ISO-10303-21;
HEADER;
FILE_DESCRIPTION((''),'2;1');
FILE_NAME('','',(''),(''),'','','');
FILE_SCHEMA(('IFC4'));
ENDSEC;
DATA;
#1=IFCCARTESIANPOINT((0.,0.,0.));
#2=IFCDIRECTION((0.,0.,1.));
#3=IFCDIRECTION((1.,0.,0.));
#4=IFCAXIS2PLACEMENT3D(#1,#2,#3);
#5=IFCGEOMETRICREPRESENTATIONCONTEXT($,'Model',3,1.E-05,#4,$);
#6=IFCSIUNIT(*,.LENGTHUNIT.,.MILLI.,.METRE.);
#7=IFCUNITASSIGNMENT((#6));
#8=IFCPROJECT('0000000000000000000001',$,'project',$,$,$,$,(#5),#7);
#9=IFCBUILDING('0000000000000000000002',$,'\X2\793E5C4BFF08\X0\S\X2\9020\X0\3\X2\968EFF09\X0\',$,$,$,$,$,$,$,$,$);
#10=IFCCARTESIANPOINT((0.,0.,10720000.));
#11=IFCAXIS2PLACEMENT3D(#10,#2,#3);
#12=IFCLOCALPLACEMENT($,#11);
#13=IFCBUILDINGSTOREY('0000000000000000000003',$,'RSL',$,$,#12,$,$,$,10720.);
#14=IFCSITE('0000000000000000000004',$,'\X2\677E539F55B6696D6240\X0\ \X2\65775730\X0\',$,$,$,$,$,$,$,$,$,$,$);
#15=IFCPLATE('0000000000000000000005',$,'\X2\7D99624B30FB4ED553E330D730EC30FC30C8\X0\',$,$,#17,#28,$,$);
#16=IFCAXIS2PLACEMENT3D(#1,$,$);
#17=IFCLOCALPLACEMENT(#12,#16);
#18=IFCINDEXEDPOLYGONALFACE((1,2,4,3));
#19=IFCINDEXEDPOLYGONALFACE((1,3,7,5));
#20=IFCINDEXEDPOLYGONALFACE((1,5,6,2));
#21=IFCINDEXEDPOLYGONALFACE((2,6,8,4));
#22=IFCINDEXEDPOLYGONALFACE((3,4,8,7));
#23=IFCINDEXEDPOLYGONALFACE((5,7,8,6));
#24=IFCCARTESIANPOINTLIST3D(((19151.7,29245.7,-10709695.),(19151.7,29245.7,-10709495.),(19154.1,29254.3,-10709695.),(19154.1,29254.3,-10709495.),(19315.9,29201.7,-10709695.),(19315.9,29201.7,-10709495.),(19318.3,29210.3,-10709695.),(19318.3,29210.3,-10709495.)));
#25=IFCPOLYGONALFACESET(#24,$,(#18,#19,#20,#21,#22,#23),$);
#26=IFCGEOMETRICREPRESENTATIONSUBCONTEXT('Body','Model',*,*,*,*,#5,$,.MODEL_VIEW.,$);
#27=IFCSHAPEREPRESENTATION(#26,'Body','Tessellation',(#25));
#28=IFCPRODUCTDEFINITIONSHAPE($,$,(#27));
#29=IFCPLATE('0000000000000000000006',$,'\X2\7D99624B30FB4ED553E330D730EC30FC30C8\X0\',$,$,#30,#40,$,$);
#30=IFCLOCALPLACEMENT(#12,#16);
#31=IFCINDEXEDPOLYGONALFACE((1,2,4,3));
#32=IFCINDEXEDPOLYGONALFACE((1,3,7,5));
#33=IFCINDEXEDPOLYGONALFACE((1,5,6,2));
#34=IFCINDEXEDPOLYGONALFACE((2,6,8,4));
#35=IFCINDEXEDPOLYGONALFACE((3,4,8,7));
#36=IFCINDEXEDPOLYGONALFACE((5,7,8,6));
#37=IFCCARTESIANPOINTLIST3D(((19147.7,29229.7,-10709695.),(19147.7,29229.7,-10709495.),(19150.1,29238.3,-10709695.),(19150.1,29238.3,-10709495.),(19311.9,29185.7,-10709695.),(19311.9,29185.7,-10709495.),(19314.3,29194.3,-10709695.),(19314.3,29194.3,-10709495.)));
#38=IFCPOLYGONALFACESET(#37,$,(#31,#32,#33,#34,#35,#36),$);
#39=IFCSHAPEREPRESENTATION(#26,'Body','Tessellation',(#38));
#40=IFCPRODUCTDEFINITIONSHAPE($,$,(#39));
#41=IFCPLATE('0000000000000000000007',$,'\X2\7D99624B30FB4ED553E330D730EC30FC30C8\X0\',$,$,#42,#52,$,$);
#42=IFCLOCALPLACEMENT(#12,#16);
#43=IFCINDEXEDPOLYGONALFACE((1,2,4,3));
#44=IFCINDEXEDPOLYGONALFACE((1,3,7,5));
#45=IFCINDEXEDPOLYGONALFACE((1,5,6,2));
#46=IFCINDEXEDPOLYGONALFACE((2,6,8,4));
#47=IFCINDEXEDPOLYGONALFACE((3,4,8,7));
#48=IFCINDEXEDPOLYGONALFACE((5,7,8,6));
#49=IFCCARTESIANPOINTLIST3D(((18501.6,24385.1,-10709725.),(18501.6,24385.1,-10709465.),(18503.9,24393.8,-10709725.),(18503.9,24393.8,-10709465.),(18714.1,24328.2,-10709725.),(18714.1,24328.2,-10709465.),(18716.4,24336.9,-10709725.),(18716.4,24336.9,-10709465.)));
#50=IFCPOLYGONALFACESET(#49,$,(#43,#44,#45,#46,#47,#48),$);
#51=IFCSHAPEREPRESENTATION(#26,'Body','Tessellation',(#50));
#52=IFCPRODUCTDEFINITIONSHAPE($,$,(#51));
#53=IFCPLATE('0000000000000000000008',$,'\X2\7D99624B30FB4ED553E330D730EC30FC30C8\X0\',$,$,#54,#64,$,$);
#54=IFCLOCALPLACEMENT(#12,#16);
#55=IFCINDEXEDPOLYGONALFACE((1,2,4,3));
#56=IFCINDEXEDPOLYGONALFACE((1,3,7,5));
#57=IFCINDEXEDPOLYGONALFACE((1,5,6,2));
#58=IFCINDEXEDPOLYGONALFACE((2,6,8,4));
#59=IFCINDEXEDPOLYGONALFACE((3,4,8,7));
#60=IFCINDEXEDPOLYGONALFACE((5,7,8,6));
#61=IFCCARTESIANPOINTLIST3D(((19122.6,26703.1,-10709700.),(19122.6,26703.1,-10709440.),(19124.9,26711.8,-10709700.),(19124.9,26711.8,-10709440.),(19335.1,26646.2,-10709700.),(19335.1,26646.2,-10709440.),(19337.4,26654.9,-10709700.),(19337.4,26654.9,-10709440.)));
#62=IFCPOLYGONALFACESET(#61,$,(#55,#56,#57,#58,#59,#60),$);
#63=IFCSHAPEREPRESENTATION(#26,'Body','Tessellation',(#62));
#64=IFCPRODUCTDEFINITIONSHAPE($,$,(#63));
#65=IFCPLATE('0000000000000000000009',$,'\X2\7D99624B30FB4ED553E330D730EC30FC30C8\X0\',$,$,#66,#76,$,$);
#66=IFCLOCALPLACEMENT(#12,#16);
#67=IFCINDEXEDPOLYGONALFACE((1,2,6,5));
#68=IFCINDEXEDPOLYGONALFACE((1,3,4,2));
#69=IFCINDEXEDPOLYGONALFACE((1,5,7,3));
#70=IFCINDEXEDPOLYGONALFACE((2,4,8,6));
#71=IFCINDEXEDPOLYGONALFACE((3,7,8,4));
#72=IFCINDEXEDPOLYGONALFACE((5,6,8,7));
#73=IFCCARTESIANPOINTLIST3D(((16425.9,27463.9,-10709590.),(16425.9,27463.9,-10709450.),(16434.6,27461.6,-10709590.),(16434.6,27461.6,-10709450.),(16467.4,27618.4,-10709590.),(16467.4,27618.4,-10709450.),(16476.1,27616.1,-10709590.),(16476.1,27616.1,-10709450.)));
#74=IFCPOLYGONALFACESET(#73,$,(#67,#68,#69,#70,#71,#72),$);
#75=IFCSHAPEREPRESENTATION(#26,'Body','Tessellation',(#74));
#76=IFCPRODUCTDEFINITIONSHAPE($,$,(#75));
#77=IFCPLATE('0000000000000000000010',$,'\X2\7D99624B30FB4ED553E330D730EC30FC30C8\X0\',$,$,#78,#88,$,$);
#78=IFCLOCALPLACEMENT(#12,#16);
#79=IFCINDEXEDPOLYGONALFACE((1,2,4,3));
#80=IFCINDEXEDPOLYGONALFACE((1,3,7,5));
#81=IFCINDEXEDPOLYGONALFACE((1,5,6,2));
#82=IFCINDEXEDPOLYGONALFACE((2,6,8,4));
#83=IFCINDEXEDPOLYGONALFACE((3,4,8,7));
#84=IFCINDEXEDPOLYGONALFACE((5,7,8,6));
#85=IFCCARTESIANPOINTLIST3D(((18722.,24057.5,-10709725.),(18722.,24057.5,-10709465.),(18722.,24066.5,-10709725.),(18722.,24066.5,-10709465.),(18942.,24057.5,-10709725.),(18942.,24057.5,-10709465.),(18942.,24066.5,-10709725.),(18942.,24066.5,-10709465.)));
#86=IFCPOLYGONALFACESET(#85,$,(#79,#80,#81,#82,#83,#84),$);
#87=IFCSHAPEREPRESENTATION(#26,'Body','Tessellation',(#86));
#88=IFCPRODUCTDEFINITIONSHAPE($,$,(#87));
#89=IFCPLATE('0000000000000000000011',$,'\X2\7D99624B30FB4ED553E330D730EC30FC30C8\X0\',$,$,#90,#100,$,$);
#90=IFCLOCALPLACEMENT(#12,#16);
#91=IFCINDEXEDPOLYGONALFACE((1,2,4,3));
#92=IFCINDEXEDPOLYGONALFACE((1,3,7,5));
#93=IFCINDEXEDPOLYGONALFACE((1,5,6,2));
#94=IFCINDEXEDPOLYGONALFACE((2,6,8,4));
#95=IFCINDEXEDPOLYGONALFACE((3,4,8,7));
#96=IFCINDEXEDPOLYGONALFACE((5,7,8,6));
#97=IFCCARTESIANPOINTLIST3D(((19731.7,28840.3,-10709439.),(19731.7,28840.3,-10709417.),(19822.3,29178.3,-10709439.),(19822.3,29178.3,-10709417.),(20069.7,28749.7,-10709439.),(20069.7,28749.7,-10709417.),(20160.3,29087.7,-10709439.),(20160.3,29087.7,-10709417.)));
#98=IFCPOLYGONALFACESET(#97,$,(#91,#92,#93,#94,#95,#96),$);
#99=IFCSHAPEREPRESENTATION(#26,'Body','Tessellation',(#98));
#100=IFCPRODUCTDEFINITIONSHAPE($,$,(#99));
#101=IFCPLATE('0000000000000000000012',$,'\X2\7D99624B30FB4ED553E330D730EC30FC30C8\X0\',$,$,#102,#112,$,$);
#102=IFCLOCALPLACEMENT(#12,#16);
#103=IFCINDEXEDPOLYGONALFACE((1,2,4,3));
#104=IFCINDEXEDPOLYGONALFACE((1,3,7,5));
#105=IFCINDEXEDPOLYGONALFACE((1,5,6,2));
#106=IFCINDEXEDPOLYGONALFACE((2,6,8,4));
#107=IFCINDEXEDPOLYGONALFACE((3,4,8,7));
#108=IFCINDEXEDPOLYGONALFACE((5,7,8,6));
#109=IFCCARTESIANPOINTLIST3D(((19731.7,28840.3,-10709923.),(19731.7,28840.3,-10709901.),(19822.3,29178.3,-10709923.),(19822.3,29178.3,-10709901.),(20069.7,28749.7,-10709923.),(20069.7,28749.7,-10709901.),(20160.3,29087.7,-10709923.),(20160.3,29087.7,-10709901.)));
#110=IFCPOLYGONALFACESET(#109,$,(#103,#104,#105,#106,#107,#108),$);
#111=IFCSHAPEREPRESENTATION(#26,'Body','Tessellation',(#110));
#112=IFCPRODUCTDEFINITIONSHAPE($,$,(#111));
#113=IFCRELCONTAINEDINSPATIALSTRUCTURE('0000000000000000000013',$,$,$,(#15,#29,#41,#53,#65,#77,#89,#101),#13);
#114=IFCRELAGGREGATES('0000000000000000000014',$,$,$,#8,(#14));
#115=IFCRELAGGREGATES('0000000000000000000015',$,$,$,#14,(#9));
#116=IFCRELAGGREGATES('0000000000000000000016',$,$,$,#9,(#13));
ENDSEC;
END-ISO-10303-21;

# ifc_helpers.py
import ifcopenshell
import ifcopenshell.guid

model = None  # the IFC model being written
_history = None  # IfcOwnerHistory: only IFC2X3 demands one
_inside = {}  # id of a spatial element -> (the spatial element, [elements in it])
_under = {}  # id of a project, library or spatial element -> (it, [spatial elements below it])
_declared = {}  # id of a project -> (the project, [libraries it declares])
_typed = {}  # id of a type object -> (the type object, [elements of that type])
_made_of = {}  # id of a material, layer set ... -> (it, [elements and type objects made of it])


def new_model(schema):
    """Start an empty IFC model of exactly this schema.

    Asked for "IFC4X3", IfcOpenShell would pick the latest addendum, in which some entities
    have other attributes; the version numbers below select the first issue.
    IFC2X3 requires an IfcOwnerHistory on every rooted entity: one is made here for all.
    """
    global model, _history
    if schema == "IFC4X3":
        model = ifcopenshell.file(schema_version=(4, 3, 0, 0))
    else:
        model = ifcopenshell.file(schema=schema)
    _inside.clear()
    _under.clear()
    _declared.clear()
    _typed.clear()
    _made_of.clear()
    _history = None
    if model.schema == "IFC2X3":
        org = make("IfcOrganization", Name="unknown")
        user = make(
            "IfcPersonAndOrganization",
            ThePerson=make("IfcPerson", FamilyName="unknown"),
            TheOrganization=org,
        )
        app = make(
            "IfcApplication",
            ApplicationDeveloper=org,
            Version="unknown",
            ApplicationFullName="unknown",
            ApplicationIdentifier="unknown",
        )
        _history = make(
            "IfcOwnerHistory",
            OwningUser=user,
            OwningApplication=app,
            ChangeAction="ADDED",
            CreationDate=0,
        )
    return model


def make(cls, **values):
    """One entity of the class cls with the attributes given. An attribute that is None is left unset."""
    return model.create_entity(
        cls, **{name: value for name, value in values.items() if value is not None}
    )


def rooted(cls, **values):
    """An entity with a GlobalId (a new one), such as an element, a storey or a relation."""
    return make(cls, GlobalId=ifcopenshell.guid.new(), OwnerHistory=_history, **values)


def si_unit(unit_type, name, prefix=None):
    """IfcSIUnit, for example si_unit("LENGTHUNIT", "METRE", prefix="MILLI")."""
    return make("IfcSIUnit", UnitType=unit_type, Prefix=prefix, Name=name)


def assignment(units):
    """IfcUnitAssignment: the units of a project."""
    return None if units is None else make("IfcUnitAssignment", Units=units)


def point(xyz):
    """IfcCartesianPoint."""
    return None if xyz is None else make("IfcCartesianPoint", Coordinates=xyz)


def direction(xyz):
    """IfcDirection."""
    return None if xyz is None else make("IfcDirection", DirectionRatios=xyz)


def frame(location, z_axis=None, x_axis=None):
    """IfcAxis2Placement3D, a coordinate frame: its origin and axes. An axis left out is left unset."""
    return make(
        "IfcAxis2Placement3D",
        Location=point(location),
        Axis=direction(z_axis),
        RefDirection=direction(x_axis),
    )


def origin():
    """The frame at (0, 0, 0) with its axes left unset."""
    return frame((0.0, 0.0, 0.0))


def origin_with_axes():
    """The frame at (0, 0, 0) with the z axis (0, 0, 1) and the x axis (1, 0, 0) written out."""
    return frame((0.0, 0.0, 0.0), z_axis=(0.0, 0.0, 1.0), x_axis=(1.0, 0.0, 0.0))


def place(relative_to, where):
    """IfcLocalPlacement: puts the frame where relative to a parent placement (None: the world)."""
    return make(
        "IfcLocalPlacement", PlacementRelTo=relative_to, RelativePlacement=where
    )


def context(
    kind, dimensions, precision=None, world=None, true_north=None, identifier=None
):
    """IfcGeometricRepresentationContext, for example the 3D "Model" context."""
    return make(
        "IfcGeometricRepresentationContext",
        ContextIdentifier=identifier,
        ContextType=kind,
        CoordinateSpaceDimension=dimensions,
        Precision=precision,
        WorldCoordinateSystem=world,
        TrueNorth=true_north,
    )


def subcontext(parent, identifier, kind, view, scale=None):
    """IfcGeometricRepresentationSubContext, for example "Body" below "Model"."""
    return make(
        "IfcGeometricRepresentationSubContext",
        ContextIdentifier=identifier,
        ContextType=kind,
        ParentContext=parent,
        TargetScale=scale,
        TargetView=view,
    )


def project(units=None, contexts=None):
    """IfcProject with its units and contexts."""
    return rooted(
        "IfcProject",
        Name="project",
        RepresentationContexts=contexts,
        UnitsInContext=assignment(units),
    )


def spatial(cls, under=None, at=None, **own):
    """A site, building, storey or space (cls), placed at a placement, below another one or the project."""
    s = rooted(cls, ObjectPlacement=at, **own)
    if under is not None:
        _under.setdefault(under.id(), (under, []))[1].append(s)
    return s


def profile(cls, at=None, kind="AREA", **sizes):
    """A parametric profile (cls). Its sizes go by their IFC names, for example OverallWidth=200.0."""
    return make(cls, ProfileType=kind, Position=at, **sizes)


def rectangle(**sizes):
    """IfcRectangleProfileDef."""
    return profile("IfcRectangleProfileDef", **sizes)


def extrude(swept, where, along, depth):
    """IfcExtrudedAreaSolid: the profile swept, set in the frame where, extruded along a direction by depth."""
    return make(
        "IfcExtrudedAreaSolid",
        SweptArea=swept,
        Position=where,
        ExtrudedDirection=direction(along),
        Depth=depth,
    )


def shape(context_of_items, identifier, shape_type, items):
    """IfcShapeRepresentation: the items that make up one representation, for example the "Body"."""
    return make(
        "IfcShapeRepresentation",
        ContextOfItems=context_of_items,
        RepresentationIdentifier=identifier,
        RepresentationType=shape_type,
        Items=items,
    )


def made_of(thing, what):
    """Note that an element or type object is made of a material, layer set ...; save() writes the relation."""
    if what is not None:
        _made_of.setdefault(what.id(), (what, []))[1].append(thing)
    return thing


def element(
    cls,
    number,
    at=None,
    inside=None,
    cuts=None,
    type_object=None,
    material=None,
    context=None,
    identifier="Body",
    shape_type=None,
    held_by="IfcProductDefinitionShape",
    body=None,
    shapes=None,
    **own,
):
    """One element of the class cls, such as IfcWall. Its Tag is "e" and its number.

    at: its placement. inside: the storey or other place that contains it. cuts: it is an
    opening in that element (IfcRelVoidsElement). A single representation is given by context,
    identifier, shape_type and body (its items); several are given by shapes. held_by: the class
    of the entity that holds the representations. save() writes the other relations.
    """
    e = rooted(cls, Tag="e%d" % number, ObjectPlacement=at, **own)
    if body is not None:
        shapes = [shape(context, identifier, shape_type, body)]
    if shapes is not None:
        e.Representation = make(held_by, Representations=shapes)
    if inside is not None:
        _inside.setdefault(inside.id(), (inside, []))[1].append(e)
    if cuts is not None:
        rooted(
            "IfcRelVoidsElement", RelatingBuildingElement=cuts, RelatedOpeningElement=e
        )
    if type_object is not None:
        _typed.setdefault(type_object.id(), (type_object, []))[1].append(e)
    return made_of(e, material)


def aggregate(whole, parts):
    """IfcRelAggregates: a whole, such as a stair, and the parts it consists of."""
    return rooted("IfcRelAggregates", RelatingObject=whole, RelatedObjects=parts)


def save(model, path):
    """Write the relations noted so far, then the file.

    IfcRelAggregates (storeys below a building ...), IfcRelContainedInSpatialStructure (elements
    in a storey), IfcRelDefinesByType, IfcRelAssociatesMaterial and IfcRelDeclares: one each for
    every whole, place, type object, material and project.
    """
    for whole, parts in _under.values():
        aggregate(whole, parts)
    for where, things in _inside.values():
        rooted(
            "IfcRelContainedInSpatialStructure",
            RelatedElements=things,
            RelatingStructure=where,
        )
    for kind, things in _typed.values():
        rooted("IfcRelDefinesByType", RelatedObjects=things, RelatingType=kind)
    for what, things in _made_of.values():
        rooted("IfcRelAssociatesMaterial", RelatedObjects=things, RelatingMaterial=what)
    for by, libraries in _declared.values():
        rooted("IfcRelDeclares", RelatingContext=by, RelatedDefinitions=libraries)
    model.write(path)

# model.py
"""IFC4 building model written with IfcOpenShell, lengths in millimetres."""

from ifc_helpers import new_model, si_unit, frame, origin, origin_with_axes, place, context, subcontext, project, spatial, rectangle, extrude, element, save


model = new_model("IFC4")

# Units and contexts
model_context = context("Model", 3, precision=1e-05, world=origin_with_axes())
body_context = subcontext(model_context, "Body", "Model", "MODEL_VIEW")
ifc_project = project(units=[si_unit("LENGTHUNIT", "METRE", prefix="MILLI")], contexts=[model_context])

# Site, building, storey
site = spatial("IfcSite", under=ifc_project, Name="松原営業所 敷地")
building = spatial("IfcBuilding", under=site, Name="社屋（S造3階）")
storey_placement = place(None, frame((0.0, 0.0, 10720000.0), z_axis=(0.0, 0.0, 1.0), x_axis=(1.0, 0.0, 0.0)))
storey = spatial("IfcBuildingStorey", under=building, at=storey_placement, Name="RSL", Elevation=10720.0)

# Plates
for number, where, z_axis, x_axis, name in (
    (1, (19152.9, 29250.0, -10709595.0), (0.965926, -0.258819, 0.0), (0.258819, 0.965926, 0.0), "継手・仕口プレート"),
    (2, (19148.9, 29234.0, -10709595.0), (0.965926, -0.258819, 0.0), (0.258819, 0.965926, 0.0), "継手・仕口プレート"),
):
    element("IfcPlate", number, at=place(storey_placement, frame(where, z_axis=z_axis, x_axis=x_axis)), inside=storey, Name=name, context=body_context, shape_type="SweptSolid", body=[
        extrude(rectangle(XDim=9.0, YDim=200.0), origin(), (0.0, 0.0, 1.0), 170.0),
    ])
for number, where, z_axis, x_axis, name in (
    (3, (18502.7, 24389.5, -10709595.0), (0.965926, -0.258819, 0.0), (0.258819, 0.965926, 0.0), "継手・仕口プレート"),
    (4, (19123.7, 26707.5, -10709570.0), (0.965926, -0.258819, 0.0), (0.258819, 0.965926, 0.0), "継手・仕口プレート"),
):
    element("IfcPlate", number, at=place(storey_placement, frame(where, z_axis=z_axis, x_axis=x_axis)), inside=storey, Name=name, context=body_context, shape_type="SweptSolid", body=[
        extrude(rectangle(XDim=9.0, YDim=260.0), origin(), (0.0, 0.0, 1.0), 220.0),
    ])
plate_1_placement = place(storey_placement, frame((16430.3, 27462.7, -10709520.0), z_axis=(0.258819, 0.965926, 0.0), x_axis=(-0.965926, 0.258819, 0.0)))
element("IfcPlate", 5, at=plate_1_placement, inside=storey, Name="継手・仕口プレート", context=body_context, shape_type="SweptSolid", body=[
    extrude(rectangle(XDim=9.0, YDim=140.0), origin(), (0.0, 0.0, 1.0), 160.0),
])
plate_2_placement = place(storey_placement, frame((18722.0, 24062.0, -10709595.0), z_axis=(1.0, 0.0, 0.0), x_axis=(0.0, 1.0, 0.0)))
element("IfcPlate", 6, at=plate_2_placement, inside=storey, Name="継手・仕口プレート", context=body_context, shape_type="SweptSolid", body=[
    extrude(rectangle(XDim=9.0, YDim=260.0), origin(), (0.0, 0.0, 1.0), 220.0),
])
for number, where, z_axis, x_axis, name in (
    (7, (19777.0, 29009.3, -10709428.0), (0.965926, -0.258819, 0.0), (0.258819, 0.965926, 0.0), "継手・仕口プレート"),
    (8, (19777.0, 29009.3, -10709912.0), (0.965926, -0.258819, 0.0), (0.258819, 0.965926, 0.0), "継手・仕口プレート"),
):
    element("IfcPlate", number, at=place(storey_placement, frame(where, z_axis=z_axis, x_axis=x_axis)), inside=storey, Name=name, context=body_context, shape_type="SweptSolid", body=[
        extrude(rectangle(XDim=350.0, YDim=22.0), origin(), (0.0, 0.0, 1.0), 350.0),
    ])

save(model, "model.ifc")
